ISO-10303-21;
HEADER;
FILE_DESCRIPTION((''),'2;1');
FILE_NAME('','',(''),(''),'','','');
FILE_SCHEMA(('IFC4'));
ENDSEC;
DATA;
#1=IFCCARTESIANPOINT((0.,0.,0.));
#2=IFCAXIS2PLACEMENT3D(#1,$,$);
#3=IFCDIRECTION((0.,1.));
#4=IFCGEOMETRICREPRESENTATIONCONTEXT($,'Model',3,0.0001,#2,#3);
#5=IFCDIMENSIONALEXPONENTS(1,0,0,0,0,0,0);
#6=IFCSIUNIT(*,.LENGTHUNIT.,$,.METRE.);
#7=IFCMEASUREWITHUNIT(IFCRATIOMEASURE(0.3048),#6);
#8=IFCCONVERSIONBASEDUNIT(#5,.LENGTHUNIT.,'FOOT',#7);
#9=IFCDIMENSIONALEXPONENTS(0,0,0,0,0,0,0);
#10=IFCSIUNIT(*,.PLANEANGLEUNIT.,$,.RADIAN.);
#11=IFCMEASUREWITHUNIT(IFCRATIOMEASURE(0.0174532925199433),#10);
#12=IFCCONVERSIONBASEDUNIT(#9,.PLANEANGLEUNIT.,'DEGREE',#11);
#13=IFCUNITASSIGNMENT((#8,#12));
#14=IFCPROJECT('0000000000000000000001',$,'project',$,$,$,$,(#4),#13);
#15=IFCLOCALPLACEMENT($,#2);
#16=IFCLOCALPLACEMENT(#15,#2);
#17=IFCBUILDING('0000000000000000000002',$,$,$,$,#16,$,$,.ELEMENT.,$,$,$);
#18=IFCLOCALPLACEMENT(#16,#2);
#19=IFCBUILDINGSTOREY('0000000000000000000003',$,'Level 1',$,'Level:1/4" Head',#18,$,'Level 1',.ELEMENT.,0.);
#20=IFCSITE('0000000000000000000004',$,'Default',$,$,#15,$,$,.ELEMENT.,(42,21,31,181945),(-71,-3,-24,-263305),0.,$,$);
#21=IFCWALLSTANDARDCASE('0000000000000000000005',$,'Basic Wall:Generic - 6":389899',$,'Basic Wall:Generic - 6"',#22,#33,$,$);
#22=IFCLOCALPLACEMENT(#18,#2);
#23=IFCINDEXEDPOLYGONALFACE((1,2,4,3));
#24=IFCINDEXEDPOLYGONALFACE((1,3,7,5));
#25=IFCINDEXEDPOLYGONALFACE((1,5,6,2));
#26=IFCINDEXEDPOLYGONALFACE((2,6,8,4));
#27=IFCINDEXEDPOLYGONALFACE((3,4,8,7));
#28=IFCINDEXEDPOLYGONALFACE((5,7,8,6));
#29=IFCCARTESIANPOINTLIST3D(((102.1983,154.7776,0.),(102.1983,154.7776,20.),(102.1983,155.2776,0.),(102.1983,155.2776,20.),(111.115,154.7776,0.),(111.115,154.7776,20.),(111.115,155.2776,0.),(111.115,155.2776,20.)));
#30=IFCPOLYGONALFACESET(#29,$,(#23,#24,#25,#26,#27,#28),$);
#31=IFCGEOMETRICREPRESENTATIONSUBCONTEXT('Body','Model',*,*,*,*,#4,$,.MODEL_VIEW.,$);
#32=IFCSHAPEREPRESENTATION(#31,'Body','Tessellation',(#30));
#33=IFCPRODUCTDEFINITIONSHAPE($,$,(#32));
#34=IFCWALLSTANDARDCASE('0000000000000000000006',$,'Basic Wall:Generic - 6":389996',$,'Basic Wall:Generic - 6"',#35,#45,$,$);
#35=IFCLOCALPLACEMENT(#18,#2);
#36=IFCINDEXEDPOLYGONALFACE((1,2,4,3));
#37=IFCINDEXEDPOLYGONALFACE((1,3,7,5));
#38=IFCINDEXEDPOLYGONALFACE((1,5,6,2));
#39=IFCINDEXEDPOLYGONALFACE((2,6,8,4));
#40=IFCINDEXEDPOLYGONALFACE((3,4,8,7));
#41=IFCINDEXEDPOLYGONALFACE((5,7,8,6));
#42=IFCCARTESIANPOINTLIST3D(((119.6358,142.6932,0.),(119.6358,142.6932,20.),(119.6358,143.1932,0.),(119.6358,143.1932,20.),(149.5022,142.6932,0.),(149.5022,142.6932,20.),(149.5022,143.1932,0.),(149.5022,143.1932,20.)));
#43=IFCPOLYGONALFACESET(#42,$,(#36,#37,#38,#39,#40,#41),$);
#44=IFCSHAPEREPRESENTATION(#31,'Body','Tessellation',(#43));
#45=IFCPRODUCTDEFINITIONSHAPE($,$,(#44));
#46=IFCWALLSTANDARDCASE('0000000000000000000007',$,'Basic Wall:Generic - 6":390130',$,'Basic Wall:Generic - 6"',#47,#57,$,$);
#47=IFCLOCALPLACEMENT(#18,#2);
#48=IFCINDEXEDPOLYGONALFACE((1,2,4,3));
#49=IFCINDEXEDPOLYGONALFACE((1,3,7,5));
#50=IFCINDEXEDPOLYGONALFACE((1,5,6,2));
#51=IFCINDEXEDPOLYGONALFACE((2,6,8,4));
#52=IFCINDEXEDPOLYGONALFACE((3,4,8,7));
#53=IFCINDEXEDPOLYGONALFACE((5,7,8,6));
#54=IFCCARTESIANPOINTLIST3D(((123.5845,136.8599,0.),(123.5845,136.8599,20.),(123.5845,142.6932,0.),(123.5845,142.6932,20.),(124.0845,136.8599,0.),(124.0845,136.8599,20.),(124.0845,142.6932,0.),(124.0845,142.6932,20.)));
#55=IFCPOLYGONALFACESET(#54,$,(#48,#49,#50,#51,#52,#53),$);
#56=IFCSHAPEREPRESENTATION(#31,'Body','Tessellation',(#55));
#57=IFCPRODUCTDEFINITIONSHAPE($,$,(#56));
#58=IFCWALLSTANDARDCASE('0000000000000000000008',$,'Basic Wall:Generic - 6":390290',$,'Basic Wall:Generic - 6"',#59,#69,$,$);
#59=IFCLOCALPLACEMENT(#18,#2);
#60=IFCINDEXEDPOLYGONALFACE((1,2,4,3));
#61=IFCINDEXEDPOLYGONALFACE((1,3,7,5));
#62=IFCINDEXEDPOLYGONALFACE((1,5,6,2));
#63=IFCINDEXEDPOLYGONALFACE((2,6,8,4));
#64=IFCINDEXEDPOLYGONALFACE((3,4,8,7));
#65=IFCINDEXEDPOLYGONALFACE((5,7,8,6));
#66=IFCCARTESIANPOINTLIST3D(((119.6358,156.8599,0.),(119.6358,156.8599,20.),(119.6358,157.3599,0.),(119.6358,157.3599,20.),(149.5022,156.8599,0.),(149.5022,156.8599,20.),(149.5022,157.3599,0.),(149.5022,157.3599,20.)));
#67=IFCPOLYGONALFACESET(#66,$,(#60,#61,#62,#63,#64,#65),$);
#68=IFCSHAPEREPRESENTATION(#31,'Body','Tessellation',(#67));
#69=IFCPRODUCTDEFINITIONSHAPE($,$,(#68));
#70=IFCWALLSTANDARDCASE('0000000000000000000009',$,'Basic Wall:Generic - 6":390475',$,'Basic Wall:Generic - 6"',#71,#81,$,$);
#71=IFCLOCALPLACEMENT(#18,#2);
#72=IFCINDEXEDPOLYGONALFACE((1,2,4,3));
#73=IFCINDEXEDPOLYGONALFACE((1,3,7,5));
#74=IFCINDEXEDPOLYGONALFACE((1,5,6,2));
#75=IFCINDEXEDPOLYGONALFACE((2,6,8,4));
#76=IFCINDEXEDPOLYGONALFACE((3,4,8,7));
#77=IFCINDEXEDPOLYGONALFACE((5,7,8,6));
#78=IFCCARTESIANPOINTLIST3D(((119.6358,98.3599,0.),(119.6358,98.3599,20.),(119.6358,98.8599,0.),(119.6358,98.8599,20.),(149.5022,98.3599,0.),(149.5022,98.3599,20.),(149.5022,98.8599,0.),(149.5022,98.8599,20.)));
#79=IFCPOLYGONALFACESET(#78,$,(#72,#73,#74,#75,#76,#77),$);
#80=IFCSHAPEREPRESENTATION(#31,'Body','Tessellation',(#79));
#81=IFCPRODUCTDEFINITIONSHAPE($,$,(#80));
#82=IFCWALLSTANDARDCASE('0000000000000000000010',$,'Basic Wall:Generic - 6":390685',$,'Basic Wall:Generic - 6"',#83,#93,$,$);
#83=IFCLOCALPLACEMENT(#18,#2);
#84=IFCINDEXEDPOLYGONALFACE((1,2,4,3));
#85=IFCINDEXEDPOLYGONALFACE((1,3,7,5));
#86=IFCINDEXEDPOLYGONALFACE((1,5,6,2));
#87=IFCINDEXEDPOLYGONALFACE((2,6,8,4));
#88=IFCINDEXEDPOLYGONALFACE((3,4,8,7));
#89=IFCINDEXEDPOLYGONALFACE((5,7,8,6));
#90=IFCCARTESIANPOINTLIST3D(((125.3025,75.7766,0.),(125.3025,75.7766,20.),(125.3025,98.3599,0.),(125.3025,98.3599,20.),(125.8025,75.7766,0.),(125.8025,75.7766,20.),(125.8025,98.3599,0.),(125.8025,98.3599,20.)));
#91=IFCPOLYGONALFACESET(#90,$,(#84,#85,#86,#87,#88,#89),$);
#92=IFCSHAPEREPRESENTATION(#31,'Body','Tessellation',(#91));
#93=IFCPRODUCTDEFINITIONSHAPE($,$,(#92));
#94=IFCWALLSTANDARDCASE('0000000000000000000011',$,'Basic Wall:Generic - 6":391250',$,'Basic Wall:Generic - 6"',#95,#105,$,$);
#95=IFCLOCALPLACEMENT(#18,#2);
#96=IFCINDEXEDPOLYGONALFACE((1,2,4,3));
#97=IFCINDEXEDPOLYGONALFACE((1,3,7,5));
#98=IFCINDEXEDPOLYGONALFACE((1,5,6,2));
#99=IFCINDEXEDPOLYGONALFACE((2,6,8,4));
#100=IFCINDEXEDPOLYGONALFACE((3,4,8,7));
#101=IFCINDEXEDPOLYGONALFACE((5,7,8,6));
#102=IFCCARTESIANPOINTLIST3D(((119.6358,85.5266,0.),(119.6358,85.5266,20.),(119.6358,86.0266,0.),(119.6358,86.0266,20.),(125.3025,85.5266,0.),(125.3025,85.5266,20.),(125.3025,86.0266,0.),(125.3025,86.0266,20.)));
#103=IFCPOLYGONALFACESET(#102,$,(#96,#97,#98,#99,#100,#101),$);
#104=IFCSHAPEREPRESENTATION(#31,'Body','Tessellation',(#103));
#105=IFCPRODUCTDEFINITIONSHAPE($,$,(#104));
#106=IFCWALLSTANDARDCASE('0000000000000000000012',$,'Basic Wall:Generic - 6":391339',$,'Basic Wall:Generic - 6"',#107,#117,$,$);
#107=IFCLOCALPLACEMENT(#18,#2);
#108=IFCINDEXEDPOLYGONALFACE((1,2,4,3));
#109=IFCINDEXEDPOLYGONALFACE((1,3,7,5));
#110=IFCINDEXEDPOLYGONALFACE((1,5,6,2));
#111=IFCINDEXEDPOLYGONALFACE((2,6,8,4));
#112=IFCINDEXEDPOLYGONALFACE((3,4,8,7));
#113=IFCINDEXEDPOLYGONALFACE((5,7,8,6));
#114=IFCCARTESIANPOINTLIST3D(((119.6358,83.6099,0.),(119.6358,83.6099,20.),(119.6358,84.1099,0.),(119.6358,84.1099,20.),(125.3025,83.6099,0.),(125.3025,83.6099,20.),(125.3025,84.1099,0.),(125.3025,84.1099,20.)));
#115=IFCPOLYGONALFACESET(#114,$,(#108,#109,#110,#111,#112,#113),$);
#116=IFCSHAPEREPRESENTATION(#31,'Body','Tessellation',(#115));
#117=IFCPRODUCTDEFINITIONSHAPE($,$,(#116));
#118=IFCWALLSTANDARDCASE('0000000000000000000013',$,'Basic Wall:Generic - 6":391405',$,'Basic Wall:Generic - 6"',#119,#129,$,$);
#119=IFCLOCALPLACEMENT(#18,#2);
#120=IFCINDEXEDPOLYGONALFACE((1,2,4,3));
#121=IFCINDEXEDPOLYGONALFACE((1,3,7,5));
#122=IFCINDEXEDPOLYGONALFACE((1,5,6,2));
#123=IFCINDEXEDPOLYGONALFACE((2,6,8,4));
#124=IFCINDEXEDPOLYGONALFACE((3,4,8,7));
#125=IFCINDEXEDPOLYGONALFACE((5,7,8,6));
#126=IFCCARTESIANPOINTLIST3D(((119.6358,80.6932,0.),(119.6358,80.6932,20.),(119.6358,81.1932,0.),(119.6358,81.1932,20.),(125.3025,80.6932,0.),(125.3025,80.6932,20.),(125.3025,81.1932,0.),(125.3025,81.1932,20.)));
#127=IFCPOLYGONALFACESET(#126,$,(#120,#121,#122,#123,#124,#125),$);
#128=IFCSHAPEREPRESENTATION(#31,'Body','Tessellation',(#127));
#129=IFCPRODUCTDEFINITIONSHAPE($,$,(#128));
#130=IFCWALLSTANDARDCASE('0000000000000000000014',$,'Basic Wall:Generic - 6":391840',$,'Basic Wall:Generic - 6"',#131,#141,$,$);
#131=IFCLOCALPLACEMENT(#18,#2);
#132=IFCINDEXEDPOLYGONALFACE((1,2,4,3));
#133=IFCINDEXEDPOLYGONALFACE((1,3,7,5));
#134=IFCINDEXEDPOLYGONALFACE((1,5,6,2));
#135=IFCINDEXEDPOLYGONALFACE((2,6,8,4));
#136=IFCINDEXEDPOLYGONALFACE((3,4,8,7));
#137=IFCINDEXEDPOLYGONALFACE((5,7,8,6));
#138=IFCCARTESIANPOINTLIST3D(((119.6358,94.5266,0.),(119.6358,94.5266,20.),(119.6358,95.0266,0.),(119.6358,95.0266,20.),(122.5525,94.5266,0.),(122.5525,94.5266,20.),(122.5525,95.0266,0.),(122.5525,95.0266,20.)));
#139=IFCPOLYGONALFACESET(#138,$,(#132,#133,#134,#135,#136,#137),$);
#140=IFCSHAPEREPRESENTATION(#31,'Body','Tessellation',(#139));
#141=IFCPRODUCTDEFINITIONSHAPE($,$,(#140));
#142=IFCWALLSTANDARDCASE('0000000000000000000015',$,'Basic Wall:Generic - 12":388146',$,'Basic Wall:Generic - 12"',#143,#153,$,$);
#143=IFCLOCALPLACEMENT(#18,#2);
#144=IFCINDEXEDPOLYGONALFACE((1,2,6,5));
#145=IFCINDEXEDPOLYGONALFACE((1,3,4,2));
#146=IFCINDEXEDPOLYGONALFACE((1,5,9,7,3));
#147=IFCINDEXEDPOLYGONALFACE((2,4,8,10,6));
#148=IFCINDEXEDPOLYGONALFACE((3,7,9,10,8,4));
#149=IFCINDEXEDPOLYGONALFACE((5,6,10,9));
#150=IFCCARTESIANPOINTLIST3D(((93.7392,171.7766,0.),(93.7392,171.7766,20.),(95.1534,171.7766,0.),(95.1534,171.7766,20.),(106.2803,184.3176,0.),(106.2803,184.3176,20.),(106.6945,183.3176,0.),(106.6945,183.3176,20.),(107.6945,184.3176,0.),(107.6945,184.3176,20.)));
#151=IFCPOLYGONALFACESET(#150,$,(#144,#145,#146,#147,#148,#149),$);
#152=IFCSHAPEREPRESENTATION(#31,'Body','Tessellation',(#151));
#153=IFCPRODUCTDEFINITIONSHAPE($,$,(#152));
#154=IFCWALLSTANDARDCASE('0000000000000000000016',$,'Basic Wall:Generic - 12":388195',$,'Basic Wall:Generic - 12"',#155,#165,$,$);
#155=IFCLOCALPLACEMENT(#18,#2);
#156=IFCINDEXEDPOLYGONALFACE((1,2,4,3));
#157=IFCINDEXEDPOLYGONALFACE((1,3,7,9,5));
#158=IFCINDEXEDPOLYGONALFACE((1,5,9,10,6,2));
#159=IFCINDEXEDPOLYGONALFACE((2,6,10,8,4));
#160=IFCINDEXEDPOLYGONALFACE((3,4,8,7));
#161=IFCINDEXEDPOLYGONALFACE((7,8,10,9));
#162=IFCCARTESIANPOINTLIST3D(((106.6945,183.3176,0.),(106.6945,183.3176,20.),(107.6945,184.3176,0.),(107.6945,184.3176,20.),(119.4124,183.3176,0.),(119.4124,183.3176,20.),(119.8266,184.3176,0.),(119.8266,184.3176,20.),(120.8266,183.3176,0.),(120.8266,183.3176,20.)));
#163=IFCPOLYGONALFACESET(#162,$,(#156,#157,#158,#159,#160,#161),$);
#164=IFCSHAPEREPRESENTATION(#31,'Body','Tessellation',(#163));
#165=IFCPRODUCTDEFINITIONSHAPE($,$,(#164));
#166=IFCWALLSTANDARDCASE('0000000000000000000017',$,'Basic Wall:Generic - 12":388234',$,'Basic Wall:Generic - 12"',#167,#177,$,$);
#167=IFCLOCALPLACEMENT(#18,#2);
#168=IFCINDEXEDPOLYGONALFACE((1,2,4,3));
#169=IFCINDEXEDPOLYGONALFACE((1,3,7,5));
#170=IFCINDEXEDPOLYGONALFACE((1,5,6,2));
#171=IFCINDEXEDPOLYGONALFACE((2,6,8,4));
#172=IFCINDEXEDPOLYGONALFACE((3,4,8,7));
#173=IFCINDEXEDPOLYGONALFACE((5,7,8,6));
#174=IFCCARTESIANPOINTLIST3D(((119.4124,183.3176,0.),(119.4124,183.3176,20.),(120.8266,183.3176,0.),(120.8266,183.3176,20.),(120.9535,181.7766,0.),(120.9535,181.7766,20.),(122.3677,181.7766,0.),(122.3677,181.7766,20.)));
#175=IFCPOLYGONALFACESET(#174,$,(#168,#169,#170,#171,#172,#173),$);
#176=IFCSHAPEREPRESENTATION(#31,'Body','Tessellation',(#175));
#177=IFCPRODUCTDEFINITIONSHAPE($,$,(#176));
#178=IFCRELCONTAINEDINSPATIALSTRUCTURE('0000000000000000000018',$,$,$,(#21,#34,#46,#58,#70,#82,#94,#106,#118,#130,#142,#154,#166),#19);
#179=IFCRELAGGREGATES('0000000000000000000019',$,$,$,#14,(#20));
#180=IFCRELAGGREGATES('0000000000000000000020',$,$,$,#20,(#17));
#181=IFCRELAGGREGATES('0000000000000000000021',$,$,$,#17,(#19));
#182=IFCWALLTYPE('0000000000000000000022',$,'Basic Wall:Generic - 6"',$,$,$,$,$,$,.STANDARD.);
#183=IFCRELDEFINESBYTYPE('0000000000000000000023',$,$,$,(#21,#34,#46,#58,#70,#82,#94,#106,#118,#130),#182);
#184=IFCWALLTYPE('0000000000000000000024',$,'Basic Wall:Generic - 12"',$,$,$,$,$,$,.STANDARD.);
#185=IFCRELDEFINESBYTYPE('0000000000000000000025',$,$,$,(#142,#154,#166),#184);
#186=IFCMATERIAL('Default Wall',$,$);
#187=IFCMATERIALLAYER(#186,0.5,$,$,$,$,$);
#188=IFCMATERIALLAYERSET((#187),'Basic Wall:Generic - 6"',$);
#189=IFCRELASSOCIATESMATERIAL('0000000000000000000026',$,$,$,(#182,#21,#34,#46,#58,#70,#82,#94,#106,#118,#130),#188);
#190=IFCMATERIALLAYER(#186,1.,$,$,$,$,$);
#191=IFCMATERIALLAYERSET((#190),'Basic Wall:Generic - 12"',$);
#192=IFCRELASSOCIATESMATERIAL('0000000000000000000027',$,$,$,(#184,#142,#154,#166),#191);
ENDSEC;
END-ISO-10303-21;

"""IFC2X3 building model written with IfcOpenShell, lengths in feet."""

from ifc_helpers import new_model, entity, si_unit, converted_unit, direction, frame, frame_2d, origin, place, context, subcontext, project, spatial, polyline, rectangle, outline, extrude, material, layer, layer_set, layer_usage, type_object, element, save


model = new_model("IFC2X3")

# Units and contexts
model_context = context("Model", 3, precision=0.0001, world=origin(), true_north=direction((0.0, 1.0)))
body_context = subcontext(model_context, "Body", "Model", "MODEL_VIEW")
ifc_project = project(units=[converted_unit("LENGTHUNIT", "FOOT", entity("IfcRatioMeasure", 0.3048), si_unit("LENGTHUNIT", "METRE"), dimensions=[1, 0, 0, 0, 0, 0, 0]), converted_unit("PLANEANGLEUNIT", "DEGREE", entity("IfcRatioMeasure", 0.0174532925199433), si_unit("PLANEANGLEUNIT", "RADIAN"), dimensions=[0, 0, 0, 0, 0, 0, 0])], contexts=[model_context])

# Site, building, storey
site_placement = place(None, origin())
site = spatial("IfcSite", under=ifc_project, at=site_placement, Name="Default", CompositionType="ELEMENT", RefLatitude=(42, 21, 31, 181945), RefLongitude=(-71, -3, -24, -263305), RefElevation=0.0)
building_placement = place(site_placement, origin())
building = spatial("IfcBuilding", under=site, at=building_placement, CompositionType="ELEMENT")
storey_placement = place(building_placement, origin())
storey = spatial("IfcBuildingStorey", under=building, at=storey_placement, Name="Level 1", ObjectType="Level:1/4\" Head", LongName="Level 1", CompositionType="ELEMENT", Elevation=0.0)

# Shared definitions
ifc_material = material(Name="Default Wall")
ifc_layer_1 = layer(ifc_material, 0.5)
ifc_layer_set_1 = layer_set([ifc_layer_1], Name="Basic Wall:Generic - 6\"")
wall_type_1 = type_object("IfcWallType", Name="Basic Wall:Generic - 6\"", PredefinedType="STANDARD", material=ifc_layer_set_1)

# Walls
ifc_layer_usage_1 = layer_usage(ifc_layer_set_1, "AXIS2", "NEGATIVE", 0.25)
wall_1_placement = place(storey_placement, frame((102.1983, 155.0276, 0.0)))
element("IfcWallStandardCase", 1, at=wall_1_placement, inside=storey, type_object=wall_type_1, material=ifc_layer_usage_1, Name="Basic Wall:Generic - 6\":389899", ObjectType="Basic Wall:Generic - 6\"", context=body_context, shape_type="SweptSolid", body=[
    extrude(rectangle(XDim=8.9167, YDim=0.5, at=frame_2d((4.4584, 0.0), x_axis=(-1.0, 0.0))), origin(), (0.0, 0.0, 1.0), 20.0),
])
ifc_layer_usage_2 = layer_usage(ifc_layer_set_1, "AXIS2", "NEGATIVE", 0.25)
wall_2_placement = place(storey_placement, frame((119.6358, 142.9432, 0.0)))
element("IfcWallStandardCase", 2, at=wall_2_placement, inside=storey, type_object=wall_type_1, material=ifc_layer_usage_2, Name="Basic Wall:Generic - 6\":389996", ObjectType="Basic Wall:Generic - 6\"", context=body_context, shape_type="SweptSolid", body=[
    extrude(rectangle(XDim=29.8664, YDim=0.5, at=frame_2d((14.9332, 0.0), x_axis=(-1.0, 0.0))), origin(), (0.0, 0.0, 1.0), 20.0),
])
ifc_layer_usage_3 = layer_usage(ifc_layer_set_1, "AXIS2", "NEGATIVE", 0.25)
wall_3_placement = place(storey_placement, frame((123.8345, 136.8599, 0.0), z_axis=(0.0, 0.0, 1.0), x_axis=(0.0, 1.0, 0.0)))
element("IfcWallStandardCase", 3, at=wall_3_placement, inside=storey, type_object=wall_type_1, material=ifc_layer_usage_3, Name="Basic Wall:Generic - 6\":390130", ObjectType="Basic Wall:Generic - 6\"", context=body_context, shape_type="SweptSolid", body=[
    extrude(rectangle(XDim=5.8333, YDim=0.5, at=frame_2d((2.9167, 0.0), x_axis=(-1.0, 0.0))), origin(), (0.0, 0.0, 1.0), 20.0),
])
ifc_layer_usage_4 = layer_usage(ifc_layer_set_1, "AXIS2", "NEGATIVE", 0.25)
wall_4_placement = place(storey_placement, frame((119.6358, 157.1099, 0.0)))
element("IfcWallStandardCase", 4, at=wall_4_placement, inside=storey, type_object=wall_type_1, material=ifc_layer_usage_4, Name="Basic Wall:Generic - 6\":390290", ObjectType="Basic Wall:Generic - 6\"", context=body_context, shape_type="SweptSolid", body=[
    extrude(rectangle(XDim=29.8664, YDim=0.5, at=frame_2d((14.9332, 0.0), x_axis=(-1.0, 0.0))), origin(), (0.0, 0.0, 1.0), 20.0),
])
ifc_layer_usage_5 = layer_usage(ifc_layer_set_1, "AXIS2", "NEGATIVE", 0.25)
wall_5_placement = place(storey_placement, frame((119.6358, 98.6099, 0.0)))
element("IfcWallStandardCase", 5, at=wall_5_placement, inside=storey, type_object=wall_type_1, material=ifc_layer_usage_5, Name="Basic Wall:Generic - 6\":390475", ObjectType="Basic Wall:Generic - 6\"", context=body_context, shape_type="SweptSolid", body=[
    extrude(rectangle(XDim=29.8664, YDim=0.5, at=frame_2d((14.9332, 0.0), x_axis=(-1.0, 0.0))), origin(), (0.0, 0.0, 1.0), 20.0),
])
ifc_layer_usage_6 = layer_usage(ifc_layer_set_1, "AXIS2", "NEGATIVE", 0.25)
wall_6_placement = place(storey_placement, frame((125.5525, 98.3599, 0.0), z_axis=(0.0, 0.0, 1.0), x_axis=(0.0, -1.0, 0.0)))
element("IfcWallStandardCase", 6, at=wall_6_placement, inside=storey, type_object=wall_type_1, material=ifc_layer_usage_6, Name="Basic Wall:Generic - 6\":390685", ObjectType="Basic Wall:Generic - 6\"", context=body_context, shape_type="SweptSolid", body=[
    extrude(rectangle(XDim=22.5833, YDim=0.5, at=frame_2d((11.2917, 0.0), x_axis=(-1.0, 0.0))), origin(), (0.0, 0.0, 1.0), 20.0),
])
ifc_layer_usage_7 = layer_usage(ifc_layer_set_1, "AXIS2", "NEGATIVE", 0.25)
wall_7_placement = place(storey_placement, frame((119.6358, 85.7766, 0.0)))
element("IfcWallStandardCase", 7, at=wall_7_placement, inside=storey, type_object=wall_type_1, material=ifc_layer_usage_7, Name="Basic Wall:Generic - 6\":391250", ObjectType="Basic Wall:Generic - 6\"", context=body_context, shape_type="SweptSolid", body=[
    extrude(rectangle(XDim=5.6667, YDim=0.5, at=frame_2d((2.8333, 0.0), x_axis=(-1.0, 0.0))), origin(), (0.0, 0.0, 1.0), 20.0),
])
ifc_layer_usage_8 = layer_usage(ifc_layer_set_1, "AXIS2", "NEGATIVE", 0.25)
wall_8_placement = place(storey_placement, frame((119.6358, 83.8599, 0.0)))
element("IfcWallStandardCase", 8, at=wall_8_placement, inside=storey, type_object=wall_type_1, material=ifc_layer_usage_8, Name="Basic Wall:Generic - 6\":391339", ObjectType="Basic Wall:Generic - 6\"", context=body_context, shape_type="SweptSolid", body=[
    extrude(rectangle(XDim=5.6667, YDim=0.5, at=frame_2d((2.8333, 0.0), x_axis=(-1.0, 0.0))), origin(), (0.0, 0.0, 1.0), 20.0),
])
ifc_layer_usage_9 = layer_usage(ifc_layer_set_1, "AXIS2", "NEGATIVE", 0.25)
wall_9_placement = place(storey_placement, frame((119.6358, 80.9432, 0.0)))
element("IfcWallStandardCase", 9, at=wall_9_placement, inside=storey, type_object=wall_type_1, material=ifc_layer_usage_9, Name="Basic Wall:Generic - 6\":391405", ObjectType="Basic Wall:Generic - 6\"", context=body_context, shape_type="SweptSolid", body=[
    extrude(rectangle(XDim=5.6667, YDim=0.5, at=frame_2d((2.8333, 0.0), x_axis=(-1.0, 0.0))), origin(), (0.0, 0.0, 1.0), 20.0),
])
ifc_layer_usage_10 = layer_usage(ifc_layer_set_1, "AXIS2", "NEGATIVE", 0.25)
wall_10_placement = place(storey_placement, frame((119.6358, 94.7766, 0.0)))
element("IfcWallStandardCase", 10, at=wall_10_placement, inside=storey, type_object=wall_type_1, material=ifc_layer_usage_10, Name="Basic Wall:Generic - 6\":391840", ObjectType="Basic Wall:Generic - 6\"", context=body_context, shape_type="SweptSolid", body=[
    extrude(rectangle(XDim=2.9167, YDim=0.5, at=frame_2d((1.4583, 0.0), x_axis=(-1.0, 0.0))), origin(), (0.0, 0.0, 1.0), 20.0),
])
ifc_layer_2 = layer(ifc_material, 1.0)
ifc_layer_set_2 = layer_set([ifc_layer_2], Name="Basic Wall:Generic - 12\"")
ifc_layer_usage_11 = layer_usage(ifc_layer_set_2, "AXIS2", "NEGATIVE", 0.5)
wall_type_2 = type_object("IfcWallType", Name="Basic Wall:Generic - 12\"", PredefinedType="STANDARD", material=ifc_layer_set_2)
wall_11_placement = place(storey_placement, frame((94.0928, 171.423, 0.0), z_axis=(0.0, 0.0, 1.0), x_axis=(0.707107, 0.707107, 0.0)))
element("IfcWallStandardCase", 11, at=wall_11_placement, inside=storey, type_object=wall_type_2, material=ifc_layer_usage_11, Name="Basic Wall:Generic - 12\":388146", ObjectType="Basic Wall:Generic - 12\"", context=body_context, shape_type="SweptSolid", body=[
    extrude(outline(polyline([(18.7357, -0.5), (17.7357, 0.5), (0.0, 0.5), (1.0, -0.5), (17.3215, -0.5), (18.7357, -0.5)])), origin(), (0.0, 0.0, 1.0), 20.0),
])
ifc_layer_usage_12 = layer_usage(ifc_layer_set_2, "AXIS2", "NEGATIVE", 0.5)
wall_12_placement = place(storey_placement, frame((106.6945, 183.8176, 0.0)))
element("IfcWallStandardCase", 12, at=wall_12_placement, inside=storey, type_object=wall_type_2, material=ifc_layer_usage_12, Name="Basic Wall:Generic - 12\":388195", ObjectType="Basic Wall:Generic - 12\"", context=body_context, shape_type="SweptSolid", body=[
    extrude(outline(polyline([(14.1322, -0.5), (13.1322, 0.5), (1.0, 0.5), (0.0, -0.5), (12.7179, -0.5), (14.1322, -0.5)])), origin(), (0.0, 0.0, 1.0), 20.0),
])
ifc_layer_usage_13 = layer_usage(ifc_layer_set_2, "AXIS2", "NEGATIVE", 0.5)
wall_13_placement = place(storey_placement, frame((119.766, 183.6712, 0.0), z_axis=(0.0, 0.0, 1.0), x_axis=(0.707107, -0.707107, 0.0)))
element("IfcWallStandardCase", 13, at=wall_13_placement, inside=storey, type_object=wall_type_2, material=ifc_layer_usage_13, Name="Basic Wall:Generic - 12\":388234", ObjectType="Basic Wall:Generic - 12\"", context=body_context, shape_type="SweptSolid", body=[
    extrude(outline(polyline([(2.1794, -0.5), (3.1794, 0.5), (1.0, 0.5), (0.0, -0.5), (2.1794, -0.5)])), origin(), (0.0, 0.0, 1.0), 20.0),
])

save(model, "model.ifc")
